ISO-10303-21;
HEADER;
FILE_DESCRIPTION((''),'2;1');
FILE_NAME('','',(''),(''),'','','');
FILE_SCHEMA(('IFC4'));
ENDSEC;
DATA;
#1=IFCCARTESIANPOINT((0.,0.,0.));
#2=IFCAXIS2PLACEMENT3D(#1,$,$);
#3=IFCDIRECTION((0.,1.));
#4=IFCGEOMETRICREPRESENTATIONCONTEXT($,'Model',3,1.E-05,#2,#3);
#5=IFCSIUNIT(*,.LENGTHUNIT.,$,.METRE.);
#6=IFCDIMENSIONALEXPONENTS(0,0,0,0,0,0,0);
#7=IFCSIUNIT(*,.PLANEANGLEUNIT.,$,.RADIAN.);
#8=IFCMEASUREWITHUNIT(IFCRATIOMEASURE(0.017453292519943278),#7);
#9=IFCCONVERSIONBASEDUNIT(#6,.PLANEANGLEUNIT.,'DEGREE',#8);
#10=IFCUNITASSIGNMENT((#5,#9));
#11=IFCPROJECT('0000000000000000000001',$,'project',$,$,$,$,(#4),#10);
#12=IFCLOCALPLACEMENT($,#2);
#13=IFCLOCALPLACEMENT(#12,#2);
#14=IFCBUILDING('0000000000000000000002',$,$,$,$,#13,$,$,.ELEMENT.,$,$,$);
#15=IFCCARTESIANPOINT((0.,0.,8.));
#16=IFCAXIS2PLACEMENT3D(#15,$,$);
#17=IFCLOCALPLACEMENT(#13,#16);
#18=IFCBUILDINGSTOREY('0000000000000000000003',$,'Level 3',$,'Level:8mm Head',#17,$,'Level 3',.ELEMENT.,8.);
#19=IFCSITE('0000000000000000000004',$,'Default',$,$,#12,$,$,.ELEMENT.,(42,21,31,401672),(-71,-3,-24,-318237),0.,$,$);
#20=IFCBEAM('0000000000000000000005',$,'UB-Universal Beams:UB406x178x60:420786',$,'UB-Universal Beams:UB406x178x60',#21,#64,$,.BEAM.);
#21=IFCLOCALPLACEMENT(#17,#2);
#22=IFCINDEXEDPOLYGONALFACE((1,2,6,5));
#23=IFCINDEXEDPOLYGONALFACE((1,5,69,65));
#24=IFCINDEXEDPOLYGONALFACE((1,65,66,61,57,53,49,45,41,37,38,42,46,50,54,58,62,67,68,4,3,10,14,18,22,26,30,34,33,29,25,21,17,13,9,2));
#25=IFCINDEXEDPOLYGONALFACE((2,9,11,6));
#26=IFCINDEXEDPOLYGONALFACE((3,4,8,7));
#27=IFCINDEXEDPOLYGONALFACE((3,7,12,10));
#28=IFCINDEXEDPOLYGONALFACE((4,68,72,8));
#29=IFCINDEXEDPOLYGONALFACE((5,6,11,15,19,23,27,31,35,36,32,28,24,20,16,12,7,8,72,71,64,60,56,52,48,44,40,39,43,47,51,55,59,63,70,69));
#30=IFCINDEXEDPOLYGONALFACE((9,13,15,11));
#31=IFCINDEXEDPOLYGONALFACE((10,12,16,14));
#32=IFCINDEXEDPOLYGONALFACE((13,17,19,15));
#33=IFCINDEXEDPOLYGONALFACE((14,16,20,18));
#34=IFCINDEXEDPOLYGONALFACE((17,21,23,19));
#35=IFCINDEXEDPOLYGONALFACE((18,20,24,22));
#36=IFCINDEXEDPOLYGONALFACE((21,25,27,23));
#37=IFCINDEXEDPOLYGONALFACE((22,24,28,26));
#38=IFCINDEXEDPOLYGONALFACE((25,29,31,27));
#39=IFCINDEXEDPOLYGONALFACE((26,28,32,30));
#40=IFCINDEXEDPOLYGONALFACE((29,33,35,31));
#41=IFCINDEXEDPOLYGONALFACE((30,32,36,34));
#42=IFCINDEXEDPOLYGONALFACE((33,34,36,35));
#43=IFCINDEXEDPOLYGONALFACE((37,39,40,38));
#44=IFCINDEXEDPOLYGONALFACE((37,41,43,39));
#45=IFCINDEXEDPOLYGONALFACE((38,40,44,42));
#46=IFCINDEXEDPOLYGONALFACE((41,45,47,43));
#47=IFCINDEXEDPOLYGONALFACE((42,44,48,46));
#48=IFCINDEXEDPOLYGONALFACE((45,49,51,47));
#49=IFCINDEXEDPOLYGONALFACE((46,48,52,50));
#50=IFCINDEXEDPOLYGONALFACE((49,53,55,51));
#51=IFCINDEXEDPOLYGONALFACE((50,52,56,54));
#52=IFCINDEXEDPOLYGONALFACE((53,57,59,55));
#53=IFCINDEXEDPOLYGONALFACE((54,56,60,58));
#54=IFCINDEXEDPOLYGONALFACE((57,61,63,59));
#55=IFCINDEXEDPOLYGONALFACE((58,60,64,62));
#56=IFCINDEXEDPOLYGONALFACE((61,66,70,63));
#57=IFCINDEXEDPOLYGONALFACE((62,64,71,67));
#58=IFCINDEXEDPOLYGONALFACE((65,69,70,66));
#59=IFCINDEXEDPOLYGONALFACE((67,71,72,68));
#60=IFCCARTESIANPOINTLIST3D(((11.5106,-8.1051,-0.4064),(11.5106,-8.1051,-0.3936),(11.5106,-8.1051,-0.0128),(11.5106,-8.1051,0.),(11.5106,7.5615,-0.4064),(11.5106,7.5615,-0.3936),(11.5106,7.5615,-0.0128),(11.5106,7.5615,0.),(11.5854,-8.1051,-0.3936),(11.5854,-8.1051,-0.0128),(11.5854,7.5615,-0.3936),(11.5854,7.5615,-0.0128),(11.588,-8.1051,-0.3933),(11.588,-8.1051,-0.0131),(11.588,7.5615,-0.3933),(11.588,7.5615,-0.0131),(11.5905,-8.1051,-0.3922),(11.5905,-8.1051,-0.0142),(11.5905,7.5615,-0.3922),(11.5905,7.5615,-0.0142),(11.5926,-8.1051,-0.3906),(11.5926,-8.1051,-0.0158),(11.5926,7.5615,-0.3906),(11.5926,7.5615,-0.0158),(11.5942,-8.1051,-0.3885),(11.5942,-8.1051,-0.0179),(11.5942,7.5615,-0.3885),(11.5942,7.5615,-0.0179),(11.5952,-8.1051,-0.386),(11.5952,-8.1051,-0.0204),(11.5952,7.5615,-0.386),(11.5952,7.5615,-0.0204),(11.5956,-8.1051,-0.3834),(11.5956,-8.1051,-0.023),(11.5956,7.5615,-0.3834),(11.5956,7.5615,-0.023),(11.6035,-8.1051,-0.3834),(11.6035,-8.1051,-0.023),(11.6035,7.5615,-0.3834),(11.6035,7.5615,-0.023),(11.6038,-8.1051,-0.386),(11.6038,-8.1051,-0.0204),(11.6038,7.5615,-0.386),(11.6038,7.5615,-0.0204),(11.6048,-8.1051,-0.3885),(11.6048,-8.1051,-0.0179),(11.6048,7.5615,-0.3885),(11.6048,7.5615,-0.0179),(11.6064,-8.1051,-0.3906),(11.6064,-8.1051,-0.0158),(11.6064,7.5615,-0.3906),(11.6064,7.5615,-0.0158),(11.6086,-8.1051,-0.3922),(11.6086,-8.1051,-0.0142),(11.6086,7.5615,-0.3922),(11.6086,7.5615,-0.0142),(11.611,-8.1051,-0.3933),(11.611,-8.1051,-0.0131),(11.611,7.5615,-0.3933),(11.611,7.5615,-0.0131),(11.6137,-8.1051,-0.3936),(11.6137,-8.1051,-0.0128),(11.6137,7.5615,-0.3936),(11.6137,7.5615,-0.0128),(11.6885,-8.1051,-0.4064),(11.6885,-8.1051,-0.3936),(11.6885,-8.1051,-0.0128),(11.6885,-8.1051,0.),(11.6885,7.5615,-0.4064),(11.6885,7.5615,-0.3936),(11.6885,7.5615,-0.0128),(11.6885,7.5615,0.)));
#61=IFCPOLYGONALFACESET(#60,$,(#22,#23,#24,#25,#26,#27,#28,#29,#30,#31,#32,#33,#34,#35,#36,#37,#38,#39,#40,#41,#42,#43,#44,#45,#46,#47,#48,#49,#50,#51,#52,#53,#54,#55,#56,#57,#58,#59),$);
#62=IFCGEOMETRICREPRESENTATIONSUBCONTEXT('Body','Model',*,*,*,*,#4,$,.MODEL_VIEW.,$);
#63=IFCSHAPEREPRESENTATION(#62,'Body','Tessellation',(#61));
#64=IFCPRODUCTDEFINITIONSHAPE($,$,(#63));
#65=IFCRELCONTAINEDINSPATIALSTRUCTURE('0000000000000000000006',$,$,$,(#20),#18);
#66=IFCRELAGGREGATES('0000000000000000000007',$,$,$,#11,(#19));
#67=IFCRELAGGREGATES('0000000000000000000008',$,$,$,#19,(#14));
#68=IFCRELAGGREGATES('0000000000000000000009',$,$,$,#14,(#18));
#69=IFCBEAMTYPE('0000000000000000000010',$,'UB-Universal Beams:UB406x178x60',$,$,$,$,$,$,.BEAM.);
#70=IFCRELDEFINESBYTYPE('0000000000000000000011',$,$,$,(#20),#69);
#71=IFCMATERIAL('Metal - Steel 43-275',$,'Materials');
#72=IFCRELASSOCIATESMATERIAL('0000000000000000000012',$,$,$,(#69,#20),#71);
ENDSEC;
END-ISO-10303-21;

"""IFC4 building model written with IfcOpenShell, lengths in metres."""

from ifc_helpers import new_model, entity, si_unit, converted_unit, direction, frame, origin, place, context, subcontext, project, spatial, line, arc, indexed_curve, outline, extrude, source, transform, mapped, material, type_object, type_shapes, element, save


model = new_model("IFC4")

# Units and contexts
model_context = context("Model", 3, precision=1e-05, world=origin(), true_north=direction((0.0, 1.0)))
body_context = subcontext(model_context, "Body", "Model", "MODEL_VIEW")
ifc_project = project(units=[si_unit("LENGTHUNIT", "METRE"), converted_unit("PLANEANGLEUNIT", "DEGREE", entity("IfcRatioMeasure", 0.017453292519943278), si_unit("PLANEANGLEUNIT", "RADIAN"), dimensions=[0, 0, 0, 0, 0, 0, 0])], contexts=[model_context])

# Site, building, storey
site_placement = place(None, origin())
site = spatial("IfcSite", under=ifc_project, at=site_placement, Name="Default", CompositionType="ELEMENT", RefLatitude=(42, 21, 31, 401672), RefLongitude=(-71, -3, -24, -318237), RefElevation=0.0)
building_placement = place(site_placement, origin())
building = spatial("IfcBuilding", under=site, at=building_placement, CompositionType="ELEMENT")
storey_placement = place(building_placement, frame((0.0, 0.0, 8.0)))
storey = spatial("IfcBuildingStorey", under=building, at=storey_placement, Name="Level 3", ObjectType="Level:8mm Head", LongName="Level 3", CompositionType="ELEMENT", Elevation=8.0)

# Shared definitions
ifc_material_1 = material(Name="Metal - Steel 43-275", Category="Materials")

# Beam
beam_type_1 = type_object("IfcBeamType", Name="UB-Universal Beams:UB406x178x60", PredefinedType="BEAM", material=ifc_material_1)
shared_shape_1 = source(origin(), body_context, "Body", "SweptSolid", [
    extrude(outline(indexed_curve([(-0.089, -0.2032), (0.0889, -0.2032), (0.0889, -0.1904), (0.0141, -0.1904), (0.0069, -0.1874), (0.0039, -0.1802), (0.0039, 0.1802), (0.0069, 0.1874), (0.0141, 0.1904), (0.0889, 0.1904), (0.0889, 0.2032), (-0.089, 0.2032), (-0.089, 0.1904), (-0.0142, 0.1904), (-0.0069, 0.1874), (-0.004, 0.1802), (-0.004, -0.1802), (-0.0069, -0.1874), (-0.0142, -0.1904), (-0.089, -0.1904)], segments=[line(1, 2, 3, 4), arc(4, 5, 6), line(6, 7), arc(7, 8, 9), line(9, 10, 11, 12, 13, 14), arc(14, 15, 16), line(16, 17), arc(17, 18, 19), line(19, 20, 1)], self_intersect=False)), frame((11.5995, -8.1051, 7.7968), z_axis=(0.0, 1.0, 0.0), x_axis=(-1.0, 0.0, 0.0)), (0.0, 0.0, 1.0), 15.6666),
])
type_shapes(beam_type_1, [shared_shape_1])
beam_1_placement = place(storey_placement, frame((0.0, 0.0, -8.0)))
element("IfcBeam", 1, at=beam_1_placement, inside=storey, type_object=beam_type_1, material=ifc_material_1, Name="UB-Universal Beams:UB406x178x60:420786", ObjectType="UB-Universal Beams:UB406x178x60", PredefinedType="BEAM", context=body_context, shape_type="MappedRepresentation", body=[
    mapped(shared_shape_1, transform((0.0, 0.0, 0.0), scale=1.0)),
])

save(model, "model.ifc")
